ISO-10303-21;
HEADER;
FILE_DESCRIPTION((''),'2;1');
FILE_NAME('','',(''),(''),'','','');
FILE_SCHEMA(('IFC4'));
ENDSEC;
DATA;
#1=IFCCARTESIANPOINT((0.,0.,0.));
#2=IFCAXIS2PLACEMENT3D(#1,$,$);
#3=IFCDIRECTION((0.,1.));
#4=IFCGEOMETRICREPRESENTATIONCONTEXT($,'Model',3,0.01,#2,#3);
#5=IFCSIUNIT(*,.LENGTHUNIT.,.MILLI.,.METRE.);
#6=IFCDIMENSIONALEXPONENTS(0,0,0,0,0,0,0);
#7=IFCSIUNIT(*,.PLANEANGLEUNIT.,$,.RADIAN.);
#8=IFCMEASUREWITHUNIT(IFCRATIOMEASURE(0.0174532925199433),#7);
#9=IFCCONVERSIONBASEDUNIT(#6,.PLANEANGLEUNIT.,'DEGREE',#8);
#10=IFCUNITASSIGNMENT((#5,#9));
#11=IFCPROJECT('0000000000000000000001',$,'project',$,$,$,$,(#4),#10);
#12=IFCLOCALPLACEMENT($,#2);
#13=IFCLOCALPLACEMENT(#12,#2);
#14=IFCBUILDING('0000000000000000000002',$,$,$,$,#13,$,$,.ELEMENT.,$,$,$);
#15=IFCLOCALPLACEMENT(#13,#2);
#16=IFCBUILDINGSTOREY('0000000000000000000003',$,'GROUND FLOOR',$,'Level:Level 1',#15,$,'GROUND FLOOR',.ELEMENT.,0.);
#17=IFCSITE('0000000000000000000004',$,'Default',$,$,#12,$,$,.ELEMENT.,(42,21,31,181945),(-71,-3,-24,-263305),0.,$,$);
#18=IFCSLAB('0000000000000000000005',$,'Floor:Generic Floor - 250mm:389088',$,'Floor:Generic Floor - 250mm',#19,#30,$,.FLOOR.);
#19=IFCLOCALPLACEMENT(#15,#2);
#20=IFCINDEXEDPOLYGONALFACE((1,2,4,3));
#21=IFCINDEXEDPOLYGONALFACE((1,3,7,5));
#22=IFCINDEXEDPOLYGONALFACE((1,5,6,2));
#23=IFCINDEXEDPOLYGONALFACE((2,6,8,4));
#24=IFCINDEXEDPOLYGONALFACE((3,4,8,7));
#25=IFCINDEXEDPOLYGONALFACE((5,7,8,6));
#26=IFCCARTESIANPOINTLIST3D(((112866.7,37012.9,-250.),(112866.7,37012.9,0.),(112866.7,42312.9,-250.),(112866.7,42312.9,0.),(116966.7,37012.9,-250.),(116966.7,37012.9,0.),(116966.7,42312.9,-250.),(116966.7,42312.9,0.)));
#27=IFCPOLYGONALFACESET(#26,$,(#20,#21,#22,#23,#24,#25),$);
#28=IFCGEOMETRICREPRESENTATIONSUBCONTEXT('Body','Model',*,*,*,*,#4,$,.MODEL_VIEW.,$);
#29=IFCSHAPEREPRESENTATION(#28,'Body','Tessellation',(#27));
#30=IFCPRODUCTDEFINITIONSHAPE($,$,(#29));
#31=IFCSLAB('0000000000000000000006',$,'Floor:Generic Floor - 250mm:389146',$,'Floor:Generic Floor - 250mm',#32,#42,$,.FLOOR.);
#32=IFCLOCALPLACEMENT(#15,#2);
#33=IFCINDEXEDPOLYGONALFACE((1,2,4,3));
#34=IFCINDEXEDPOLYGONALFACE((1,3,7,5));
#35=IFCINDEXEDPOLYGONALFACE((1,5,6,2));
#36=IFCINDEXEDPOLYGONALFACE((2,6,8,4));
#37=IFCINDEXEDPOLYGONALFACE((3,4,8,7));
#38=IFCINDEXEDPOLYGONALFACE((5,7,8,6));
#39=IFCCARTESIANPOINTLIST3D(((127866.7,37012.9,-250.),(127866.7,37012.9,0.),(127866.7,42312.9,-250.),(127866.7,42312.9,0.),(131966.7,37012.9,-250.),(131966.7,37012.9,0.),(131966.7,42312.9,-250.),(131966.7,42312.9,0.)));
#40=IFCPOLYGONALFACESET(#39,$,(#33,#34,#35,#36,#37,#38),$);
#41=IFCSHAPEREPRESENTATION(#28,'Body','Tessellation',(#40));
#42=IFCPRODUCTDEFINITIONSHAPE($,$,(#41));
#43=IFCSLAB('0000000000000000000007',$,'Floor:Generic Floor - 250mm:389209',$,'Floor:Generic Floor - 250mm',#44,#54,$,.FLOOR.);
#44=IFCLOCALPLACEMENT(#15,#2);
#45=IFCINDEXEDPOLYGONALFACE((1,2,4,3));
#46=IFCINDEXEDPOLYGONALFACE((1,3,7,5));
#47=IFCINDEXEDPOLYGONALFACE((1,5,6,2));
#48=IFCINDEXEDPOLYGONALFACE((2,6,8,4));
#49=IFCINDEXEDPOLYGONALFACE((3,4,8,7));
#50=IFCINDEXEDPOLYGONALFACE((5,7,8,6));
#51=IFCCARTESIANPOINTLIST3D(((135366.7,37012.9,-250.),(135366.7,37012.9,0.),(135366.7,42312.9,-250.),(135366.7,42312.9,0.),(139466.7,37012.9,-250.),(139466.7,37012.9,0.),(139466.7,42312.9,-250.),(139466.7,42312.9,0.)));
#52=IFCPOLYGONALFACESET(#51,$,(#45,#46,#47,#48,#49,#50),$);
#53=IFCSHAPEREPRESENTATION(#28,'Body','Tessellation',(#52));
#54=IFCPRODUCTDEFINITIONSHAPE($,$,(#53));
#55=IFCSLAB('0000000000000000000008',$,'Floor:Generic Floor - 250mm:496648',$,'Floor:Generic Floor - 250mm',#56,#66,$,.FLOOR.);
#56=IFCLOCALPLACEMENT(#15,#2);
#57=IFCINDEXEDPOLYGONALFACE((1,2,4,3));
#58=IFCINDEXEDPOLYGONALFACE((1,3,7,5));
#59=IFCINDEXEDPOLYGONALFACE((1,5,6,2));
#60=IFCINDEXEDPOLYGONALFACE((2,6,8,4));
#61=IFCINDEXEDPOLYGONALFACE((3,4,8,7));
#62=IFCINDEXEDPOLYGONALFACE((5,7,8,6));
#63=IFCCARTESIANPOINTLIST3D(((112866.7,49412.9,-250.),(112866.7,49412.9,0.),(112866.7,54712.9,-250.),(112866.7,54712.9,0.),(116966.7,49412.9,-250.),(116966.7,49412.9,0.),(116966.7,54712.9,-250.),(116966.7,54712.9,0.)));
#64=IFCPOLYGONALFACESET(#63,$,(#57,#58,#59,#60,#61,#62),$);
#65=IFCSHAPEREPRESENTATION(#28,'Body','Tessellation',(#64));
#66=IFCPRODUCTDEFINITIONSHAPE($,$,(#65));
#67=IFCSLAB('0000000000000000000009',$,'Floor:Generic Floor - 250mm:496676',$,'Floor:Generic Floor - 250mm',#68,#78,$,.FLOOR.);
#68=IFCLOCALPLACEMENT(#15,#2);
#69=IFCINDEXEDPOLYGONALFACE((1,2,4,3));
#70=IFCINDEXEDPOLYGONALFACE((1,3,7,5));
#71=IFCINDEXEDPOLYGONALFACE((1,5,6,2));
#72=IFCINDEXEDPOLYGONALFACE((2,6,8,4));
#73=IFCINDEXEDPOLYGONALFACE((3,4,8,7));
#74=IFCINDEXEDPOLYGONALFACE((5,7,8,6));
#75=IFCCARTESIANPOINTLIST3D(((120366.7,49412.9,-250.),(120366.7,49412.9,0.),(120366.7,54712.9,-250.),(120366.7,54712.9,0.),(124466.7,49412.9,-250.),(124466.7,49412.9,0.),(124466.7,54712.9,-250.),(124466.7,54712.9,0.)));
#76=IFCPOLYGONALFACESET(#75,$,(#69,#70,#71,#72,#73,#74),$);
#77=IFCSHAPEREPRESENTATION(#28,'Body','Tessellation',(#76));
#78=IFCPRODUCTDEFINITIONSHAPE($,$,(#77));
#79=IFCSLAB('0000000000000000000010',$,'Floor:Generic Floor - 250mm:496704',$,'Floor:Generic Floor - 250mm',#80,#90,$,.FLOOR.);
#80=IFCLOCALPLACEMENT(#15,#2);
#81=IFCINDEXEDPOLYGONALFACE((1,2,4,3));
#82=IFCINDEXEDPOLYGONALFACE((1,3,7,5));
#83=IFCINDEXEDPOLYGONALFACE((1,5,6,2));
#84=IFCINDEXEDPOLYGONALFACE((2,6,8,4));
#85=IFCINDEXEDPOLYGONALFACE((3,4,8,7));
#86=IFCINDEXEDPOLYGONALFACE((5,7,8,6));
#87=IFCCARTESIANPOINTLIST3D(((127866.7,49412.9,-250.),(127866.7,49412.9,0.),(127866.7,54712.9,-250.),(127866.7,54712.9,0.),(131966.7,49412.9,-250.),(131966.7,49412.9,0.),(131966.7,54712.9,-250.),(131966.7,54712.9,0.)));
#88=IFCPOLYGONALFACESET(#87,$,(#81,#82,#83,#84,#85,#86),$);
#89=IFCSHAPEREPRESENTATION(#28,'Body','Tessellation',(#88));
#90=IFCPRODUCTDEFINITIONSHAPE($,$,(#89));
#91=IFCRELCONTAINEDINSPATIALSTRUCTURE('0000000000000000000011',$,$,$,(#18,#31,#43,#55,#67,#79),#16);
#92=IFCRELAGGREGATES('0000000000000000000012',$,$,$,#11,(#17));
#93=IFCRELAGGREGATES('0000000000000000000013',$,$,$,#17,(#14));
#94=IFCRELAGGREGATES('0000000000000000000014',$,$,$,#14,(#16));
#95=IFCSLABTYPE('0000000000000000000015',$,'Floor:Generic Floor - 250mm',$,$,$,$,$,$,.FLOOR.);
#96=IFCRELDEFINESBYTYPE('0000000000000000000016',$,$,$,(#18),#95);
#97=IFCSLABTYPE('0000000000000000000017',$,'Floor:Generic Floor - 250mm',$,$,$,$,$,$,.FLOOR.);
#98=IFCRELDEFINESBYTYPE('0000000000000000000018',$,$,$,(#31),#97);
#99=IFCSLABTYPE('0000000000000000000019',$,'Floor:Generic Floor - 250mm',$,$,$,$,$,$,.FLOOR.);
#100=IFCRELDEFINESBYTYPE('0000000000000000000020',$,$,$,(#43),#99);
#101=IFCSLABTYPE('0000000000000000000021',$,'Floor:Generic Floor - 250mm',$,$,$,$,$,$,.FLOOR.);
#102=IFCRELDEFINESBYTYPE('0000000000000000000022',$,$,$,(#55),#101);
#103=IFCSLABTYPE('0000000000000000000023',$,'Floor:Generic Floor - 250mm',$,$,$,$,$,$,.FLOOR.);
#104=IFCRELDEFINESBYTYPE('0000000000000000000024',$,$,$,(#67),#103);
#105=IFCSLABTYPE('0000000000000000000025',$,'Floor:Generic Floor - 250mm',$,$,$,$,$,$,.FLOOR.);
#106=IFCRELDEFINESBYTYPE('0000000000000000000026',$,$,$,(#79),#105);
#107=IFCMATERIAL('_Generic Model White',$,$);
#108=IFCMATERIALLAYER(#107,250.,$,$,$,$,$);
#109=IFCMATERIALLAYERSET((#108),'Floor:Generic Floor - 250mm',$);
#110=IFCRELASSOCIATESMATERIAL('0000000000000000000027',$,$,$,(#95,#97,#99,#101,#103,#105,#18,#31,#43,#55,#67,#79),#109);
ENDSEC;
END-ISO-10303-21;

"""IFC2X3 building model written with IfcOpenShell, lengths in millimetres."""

from ifc_helpers import new_model, entity, si_unit, converted_unit, direction, frame, frame_2d, origin, place, context, subcontext, project, spatial, rectangle, extrude, material, layer, layer_set, layer_usage, type_object, element, save


model = new_model("IFC2X3")

# Units and contexts
model_context = context("Model", 3, precision=0.01, world=origin(), true_north=direction((0.0, 1.0)))
body_context = subcontext(model_context, "Body", "Model", "MODEL_VIEW")
ifc_project = project(units=[si_unit("LENGTHUNIT", "METRE", prefix="MILLI"), converted_unit("PLANEANGLEUNIT", "DEGREE", entity("IfcRatioMeasure", 0.0174532925199433), si_unit("PLANEANGLEUNIT", "RADIAN"), dimensions=[0, 0, 0, 0, 0, 0, 0])], contexts=[model_context])

# Site, building, storey
site_placement = place(None, origin())
site = spatial("IfcSite", under=ifc_project, at=site_placement, Name="Default", CompositionType="ELEMENT", RefLatitude=(42, 21, 31, 181945), RefLongitude=(-71, -3, -24, -263305), RefElevation=0.0)
building_placement = place(site_placement, origin())
building = spatial("IfcBuilding", under=site, at=building_placement, CompositionType="ELEMENT")
storey_placement = place(building_placement, origin())
storey = spatial("IfcBuildingStorey", under=building, at=storey_placement, Name="GROUND FLOOR", ObjectType="Level:Level 1", LongName="GROUND FLOOR", CompositionType="ELEMENT", Elevation=0.0)

# Slabs
ifc_material_1 = material(Name="_Generic Model White")
ifc_layer_1 = layer(ifc_material_1, 250.0)
ifc_layer_set_1 = layer_set([ifc_layer_1], Name="Floor:Generic Floor - 250mm")
ifc_layer_usage_1 = layer_usage(ifc_layer_set_1, "AXIS3", "POSITIVE", 0.0)
slab_type_1 = type_object("IfcSlabType", Name="Floor:Generic Floor - 250mm", PredefinedType="FLOOR", material=ifc_layer_set_1)
slab_1_placement = place(storey_placement, origin())
element("IfcSlab", 1, at=slab_1_placement, inside=storey, type_object=slab_type_1, material=ifc_layer_usage_1, Name="Floor:Generic Floor - 250mm:389088", ObjectType="Floor:Generic Floor - 250mm", PredefinedType="FLOOR", context=body_context, shape_type="SweptSolid", body=[
    extrude(rectangle(XDim=5300.0, YDim=4100.0, at=frame_2d((0.0, 0.0), x_axis=(1.0, 0.0))), frame((114916.7, 39662.9, 0.0), z_axis=(0.0, 0.0, -1.0), x_axis=(0.0, 1.0, 0.0)), (0.0, 0.0, 1.0), 250.0),
])
ifc_layer_usage_2 = layer_usage(ifc_layer_set_1, "AXIS3", "POSITIVE", 0.0)
slab_type_2 = type_object("IfcSlabType", Name="Floor:Generic Floor - 250mm", PredefinedType="FLOOR", material=ifc_layer_set_1)
slab_2_placement = place(storey_placement, origin())
element("IfcSlab", 2, at=slab_2_placement, inside=storey, type_object=slab_type_2, material=ifc_layer_usage_2, Name="Floor:Generic Floor - 250mm:389146", ObjectType="Floor:Generic Floor - 250mm", PredefinedType="FLOOR", context=body_context, shape_type="SweptSolid", body=[
    extrude(rectangle(XDim=5300.0, YDim=4100.0, at=frame_2d((0.0, 0.0), x_axis=(1.0, 0.0))), frame((129916.7, 39662.9, 0.0), z_axis=(0.0, 0.0, -1.0), x_axis=(0.0, 1.0, 0.0)), (0.0, 0.0, 1.0), 250.0),
])
ifc_layer_usage_3 = layer_usage(ifc_layer_set_1, "AXIS3", "POSITIVE", 0.0)
slab_type_3 = type_object("IfcSlabType", Name="Floor:Generic Floor - 250mm", PredefinedType="FLOOR", material=ifc_layer_set_1)
slab_3_placement = place(storey_placement, origin())
element("IfcSlab", 3, at=slab_3_placement, inside=storey, type_object=slab_type_3, material=ifc_layer_usage_3, Name="Floor:Generic Floor - 250mm:389209", ObjectType="Floor:Generic Floor - 250mm", PredefinedType="FLOOR", context=body_context, shape_type="SweptSolid", body=[
    extrude(rectangle(XDim=5300.0, YDim=4100.0, at=frame_2d((0.0, 0.0), x_axis=(1.0, 0.0))), frame((137416.7, 39662.9, 0.0), z_axis=(0.0, 0.0, -1.0), x_axis=(0.0, 1.0, 0.0)), (0.0, 0.0, 1.0), 250.0),
])
ifc_layer_usage_4 = layer_usage(ifc_layer_set_1, "AXIS3", "POSITIVE", 0.0)
slab_type_4 = type_object("IfcSlabType", Name="Floor:Generic Floor - 250mm", PredefinedType="FLOOR", material=ifc_layer_set_1)
slab_4_placement = place(storey_placement, origin())
element("IfcSlab", 4, at=slab_4_placement, inside=storey, type_object=slab_type_4, material=ifc_layer_usage_4, Name="Floor:Generic Floor - 250mm:496648", ObjectType="Floor:Generic Floor - 250mm", PredefinedType="FLOOR", context=body_context, shape_type="SweptSolid", body=[
    extrude(rectangle(XDim=5300.0, YDim=4100.0, at=frame_2d((0.0, 0.0), x_axis=(1.0, 0.0))), frame((114916.7, 52062.9, 0.0), z_axis=(0.0, 0.0, -1.0), x_axis=(0.0, 1.0, 0.0)), (0.0, 0.0, 1.0), 250.0),
])
ifc_layer_usage_5 = layer_usage(ifc_layer_set_1, "AXIS3", "POSITIVE", 0.0)
slab_type_5 = type_object("IfcSlabType", Name="Floor:Generic Floor - 250mm", PredefinedType="FLOOR", material=ifc_layer_set_1)
slab_5_placement = place(storey_placement, origin())
element("IfcSlab", 5, at=slab_5_placement, inside=storey, type_object=slab_type_5, material=ifc_layer_usage_5, Name="Floor:Generic Floor - 250mm:496676", ObjectType="Floor:Generic Floor - 250mm", PredefinedType="FLOOR", context=body_context, shape_type="SweptSolid", body=[
    extrude(rectangle(XDim=5300.0, YDim=4100.0, at=frame_2d((0.0, 0.0), x_axis=(1.0, 0.0))), frame((122416.7, 52062.9, 0.0), z_axis=(0.0, 0.0, -1.0), x_axis=(0.0, 1.0, 0.0)), (0.0, 0.0, 1.0), 250.0),
])
ifc_layer_usage_6 = layer_usage(ifc_layer_set_1, "AXIS3", "POSITIVE", 0.0)
slab_type_6 = type_object("IfcSlabType", Name="Floor:Generic Floor - 250mm", PredefinedType="FLOOR", material=ifc_layer_set_1)
slab_6_placement = place(storey_placement, origin())
element("IfcSlab", 6, at=slab_6_placement, inside=storey, type_object=slab_type_6, material=ifc_layer_usage_6, Name="Floor:Generic Floor - 250mm:496704", ObjectType="Floor:Generic Floor - 250mm", PredefinedType="FLOOR", context=body_context, shape_type="SweptSolid", body=[
    extrude(rectangle(XDim=5300.0, YDim=4100.0, at=frame_2d((0.0, 0.0), x_axis=(1.0, 0.0))), frame((129916.7, 52062.9, 0.0), z_axis=(0.0, 0.0, -1.0), x_axis=(0.0, 1.0, 0.0)), (0.0, 0.0, 1.0), 250.0),
])

save(model, "model.ifc")
